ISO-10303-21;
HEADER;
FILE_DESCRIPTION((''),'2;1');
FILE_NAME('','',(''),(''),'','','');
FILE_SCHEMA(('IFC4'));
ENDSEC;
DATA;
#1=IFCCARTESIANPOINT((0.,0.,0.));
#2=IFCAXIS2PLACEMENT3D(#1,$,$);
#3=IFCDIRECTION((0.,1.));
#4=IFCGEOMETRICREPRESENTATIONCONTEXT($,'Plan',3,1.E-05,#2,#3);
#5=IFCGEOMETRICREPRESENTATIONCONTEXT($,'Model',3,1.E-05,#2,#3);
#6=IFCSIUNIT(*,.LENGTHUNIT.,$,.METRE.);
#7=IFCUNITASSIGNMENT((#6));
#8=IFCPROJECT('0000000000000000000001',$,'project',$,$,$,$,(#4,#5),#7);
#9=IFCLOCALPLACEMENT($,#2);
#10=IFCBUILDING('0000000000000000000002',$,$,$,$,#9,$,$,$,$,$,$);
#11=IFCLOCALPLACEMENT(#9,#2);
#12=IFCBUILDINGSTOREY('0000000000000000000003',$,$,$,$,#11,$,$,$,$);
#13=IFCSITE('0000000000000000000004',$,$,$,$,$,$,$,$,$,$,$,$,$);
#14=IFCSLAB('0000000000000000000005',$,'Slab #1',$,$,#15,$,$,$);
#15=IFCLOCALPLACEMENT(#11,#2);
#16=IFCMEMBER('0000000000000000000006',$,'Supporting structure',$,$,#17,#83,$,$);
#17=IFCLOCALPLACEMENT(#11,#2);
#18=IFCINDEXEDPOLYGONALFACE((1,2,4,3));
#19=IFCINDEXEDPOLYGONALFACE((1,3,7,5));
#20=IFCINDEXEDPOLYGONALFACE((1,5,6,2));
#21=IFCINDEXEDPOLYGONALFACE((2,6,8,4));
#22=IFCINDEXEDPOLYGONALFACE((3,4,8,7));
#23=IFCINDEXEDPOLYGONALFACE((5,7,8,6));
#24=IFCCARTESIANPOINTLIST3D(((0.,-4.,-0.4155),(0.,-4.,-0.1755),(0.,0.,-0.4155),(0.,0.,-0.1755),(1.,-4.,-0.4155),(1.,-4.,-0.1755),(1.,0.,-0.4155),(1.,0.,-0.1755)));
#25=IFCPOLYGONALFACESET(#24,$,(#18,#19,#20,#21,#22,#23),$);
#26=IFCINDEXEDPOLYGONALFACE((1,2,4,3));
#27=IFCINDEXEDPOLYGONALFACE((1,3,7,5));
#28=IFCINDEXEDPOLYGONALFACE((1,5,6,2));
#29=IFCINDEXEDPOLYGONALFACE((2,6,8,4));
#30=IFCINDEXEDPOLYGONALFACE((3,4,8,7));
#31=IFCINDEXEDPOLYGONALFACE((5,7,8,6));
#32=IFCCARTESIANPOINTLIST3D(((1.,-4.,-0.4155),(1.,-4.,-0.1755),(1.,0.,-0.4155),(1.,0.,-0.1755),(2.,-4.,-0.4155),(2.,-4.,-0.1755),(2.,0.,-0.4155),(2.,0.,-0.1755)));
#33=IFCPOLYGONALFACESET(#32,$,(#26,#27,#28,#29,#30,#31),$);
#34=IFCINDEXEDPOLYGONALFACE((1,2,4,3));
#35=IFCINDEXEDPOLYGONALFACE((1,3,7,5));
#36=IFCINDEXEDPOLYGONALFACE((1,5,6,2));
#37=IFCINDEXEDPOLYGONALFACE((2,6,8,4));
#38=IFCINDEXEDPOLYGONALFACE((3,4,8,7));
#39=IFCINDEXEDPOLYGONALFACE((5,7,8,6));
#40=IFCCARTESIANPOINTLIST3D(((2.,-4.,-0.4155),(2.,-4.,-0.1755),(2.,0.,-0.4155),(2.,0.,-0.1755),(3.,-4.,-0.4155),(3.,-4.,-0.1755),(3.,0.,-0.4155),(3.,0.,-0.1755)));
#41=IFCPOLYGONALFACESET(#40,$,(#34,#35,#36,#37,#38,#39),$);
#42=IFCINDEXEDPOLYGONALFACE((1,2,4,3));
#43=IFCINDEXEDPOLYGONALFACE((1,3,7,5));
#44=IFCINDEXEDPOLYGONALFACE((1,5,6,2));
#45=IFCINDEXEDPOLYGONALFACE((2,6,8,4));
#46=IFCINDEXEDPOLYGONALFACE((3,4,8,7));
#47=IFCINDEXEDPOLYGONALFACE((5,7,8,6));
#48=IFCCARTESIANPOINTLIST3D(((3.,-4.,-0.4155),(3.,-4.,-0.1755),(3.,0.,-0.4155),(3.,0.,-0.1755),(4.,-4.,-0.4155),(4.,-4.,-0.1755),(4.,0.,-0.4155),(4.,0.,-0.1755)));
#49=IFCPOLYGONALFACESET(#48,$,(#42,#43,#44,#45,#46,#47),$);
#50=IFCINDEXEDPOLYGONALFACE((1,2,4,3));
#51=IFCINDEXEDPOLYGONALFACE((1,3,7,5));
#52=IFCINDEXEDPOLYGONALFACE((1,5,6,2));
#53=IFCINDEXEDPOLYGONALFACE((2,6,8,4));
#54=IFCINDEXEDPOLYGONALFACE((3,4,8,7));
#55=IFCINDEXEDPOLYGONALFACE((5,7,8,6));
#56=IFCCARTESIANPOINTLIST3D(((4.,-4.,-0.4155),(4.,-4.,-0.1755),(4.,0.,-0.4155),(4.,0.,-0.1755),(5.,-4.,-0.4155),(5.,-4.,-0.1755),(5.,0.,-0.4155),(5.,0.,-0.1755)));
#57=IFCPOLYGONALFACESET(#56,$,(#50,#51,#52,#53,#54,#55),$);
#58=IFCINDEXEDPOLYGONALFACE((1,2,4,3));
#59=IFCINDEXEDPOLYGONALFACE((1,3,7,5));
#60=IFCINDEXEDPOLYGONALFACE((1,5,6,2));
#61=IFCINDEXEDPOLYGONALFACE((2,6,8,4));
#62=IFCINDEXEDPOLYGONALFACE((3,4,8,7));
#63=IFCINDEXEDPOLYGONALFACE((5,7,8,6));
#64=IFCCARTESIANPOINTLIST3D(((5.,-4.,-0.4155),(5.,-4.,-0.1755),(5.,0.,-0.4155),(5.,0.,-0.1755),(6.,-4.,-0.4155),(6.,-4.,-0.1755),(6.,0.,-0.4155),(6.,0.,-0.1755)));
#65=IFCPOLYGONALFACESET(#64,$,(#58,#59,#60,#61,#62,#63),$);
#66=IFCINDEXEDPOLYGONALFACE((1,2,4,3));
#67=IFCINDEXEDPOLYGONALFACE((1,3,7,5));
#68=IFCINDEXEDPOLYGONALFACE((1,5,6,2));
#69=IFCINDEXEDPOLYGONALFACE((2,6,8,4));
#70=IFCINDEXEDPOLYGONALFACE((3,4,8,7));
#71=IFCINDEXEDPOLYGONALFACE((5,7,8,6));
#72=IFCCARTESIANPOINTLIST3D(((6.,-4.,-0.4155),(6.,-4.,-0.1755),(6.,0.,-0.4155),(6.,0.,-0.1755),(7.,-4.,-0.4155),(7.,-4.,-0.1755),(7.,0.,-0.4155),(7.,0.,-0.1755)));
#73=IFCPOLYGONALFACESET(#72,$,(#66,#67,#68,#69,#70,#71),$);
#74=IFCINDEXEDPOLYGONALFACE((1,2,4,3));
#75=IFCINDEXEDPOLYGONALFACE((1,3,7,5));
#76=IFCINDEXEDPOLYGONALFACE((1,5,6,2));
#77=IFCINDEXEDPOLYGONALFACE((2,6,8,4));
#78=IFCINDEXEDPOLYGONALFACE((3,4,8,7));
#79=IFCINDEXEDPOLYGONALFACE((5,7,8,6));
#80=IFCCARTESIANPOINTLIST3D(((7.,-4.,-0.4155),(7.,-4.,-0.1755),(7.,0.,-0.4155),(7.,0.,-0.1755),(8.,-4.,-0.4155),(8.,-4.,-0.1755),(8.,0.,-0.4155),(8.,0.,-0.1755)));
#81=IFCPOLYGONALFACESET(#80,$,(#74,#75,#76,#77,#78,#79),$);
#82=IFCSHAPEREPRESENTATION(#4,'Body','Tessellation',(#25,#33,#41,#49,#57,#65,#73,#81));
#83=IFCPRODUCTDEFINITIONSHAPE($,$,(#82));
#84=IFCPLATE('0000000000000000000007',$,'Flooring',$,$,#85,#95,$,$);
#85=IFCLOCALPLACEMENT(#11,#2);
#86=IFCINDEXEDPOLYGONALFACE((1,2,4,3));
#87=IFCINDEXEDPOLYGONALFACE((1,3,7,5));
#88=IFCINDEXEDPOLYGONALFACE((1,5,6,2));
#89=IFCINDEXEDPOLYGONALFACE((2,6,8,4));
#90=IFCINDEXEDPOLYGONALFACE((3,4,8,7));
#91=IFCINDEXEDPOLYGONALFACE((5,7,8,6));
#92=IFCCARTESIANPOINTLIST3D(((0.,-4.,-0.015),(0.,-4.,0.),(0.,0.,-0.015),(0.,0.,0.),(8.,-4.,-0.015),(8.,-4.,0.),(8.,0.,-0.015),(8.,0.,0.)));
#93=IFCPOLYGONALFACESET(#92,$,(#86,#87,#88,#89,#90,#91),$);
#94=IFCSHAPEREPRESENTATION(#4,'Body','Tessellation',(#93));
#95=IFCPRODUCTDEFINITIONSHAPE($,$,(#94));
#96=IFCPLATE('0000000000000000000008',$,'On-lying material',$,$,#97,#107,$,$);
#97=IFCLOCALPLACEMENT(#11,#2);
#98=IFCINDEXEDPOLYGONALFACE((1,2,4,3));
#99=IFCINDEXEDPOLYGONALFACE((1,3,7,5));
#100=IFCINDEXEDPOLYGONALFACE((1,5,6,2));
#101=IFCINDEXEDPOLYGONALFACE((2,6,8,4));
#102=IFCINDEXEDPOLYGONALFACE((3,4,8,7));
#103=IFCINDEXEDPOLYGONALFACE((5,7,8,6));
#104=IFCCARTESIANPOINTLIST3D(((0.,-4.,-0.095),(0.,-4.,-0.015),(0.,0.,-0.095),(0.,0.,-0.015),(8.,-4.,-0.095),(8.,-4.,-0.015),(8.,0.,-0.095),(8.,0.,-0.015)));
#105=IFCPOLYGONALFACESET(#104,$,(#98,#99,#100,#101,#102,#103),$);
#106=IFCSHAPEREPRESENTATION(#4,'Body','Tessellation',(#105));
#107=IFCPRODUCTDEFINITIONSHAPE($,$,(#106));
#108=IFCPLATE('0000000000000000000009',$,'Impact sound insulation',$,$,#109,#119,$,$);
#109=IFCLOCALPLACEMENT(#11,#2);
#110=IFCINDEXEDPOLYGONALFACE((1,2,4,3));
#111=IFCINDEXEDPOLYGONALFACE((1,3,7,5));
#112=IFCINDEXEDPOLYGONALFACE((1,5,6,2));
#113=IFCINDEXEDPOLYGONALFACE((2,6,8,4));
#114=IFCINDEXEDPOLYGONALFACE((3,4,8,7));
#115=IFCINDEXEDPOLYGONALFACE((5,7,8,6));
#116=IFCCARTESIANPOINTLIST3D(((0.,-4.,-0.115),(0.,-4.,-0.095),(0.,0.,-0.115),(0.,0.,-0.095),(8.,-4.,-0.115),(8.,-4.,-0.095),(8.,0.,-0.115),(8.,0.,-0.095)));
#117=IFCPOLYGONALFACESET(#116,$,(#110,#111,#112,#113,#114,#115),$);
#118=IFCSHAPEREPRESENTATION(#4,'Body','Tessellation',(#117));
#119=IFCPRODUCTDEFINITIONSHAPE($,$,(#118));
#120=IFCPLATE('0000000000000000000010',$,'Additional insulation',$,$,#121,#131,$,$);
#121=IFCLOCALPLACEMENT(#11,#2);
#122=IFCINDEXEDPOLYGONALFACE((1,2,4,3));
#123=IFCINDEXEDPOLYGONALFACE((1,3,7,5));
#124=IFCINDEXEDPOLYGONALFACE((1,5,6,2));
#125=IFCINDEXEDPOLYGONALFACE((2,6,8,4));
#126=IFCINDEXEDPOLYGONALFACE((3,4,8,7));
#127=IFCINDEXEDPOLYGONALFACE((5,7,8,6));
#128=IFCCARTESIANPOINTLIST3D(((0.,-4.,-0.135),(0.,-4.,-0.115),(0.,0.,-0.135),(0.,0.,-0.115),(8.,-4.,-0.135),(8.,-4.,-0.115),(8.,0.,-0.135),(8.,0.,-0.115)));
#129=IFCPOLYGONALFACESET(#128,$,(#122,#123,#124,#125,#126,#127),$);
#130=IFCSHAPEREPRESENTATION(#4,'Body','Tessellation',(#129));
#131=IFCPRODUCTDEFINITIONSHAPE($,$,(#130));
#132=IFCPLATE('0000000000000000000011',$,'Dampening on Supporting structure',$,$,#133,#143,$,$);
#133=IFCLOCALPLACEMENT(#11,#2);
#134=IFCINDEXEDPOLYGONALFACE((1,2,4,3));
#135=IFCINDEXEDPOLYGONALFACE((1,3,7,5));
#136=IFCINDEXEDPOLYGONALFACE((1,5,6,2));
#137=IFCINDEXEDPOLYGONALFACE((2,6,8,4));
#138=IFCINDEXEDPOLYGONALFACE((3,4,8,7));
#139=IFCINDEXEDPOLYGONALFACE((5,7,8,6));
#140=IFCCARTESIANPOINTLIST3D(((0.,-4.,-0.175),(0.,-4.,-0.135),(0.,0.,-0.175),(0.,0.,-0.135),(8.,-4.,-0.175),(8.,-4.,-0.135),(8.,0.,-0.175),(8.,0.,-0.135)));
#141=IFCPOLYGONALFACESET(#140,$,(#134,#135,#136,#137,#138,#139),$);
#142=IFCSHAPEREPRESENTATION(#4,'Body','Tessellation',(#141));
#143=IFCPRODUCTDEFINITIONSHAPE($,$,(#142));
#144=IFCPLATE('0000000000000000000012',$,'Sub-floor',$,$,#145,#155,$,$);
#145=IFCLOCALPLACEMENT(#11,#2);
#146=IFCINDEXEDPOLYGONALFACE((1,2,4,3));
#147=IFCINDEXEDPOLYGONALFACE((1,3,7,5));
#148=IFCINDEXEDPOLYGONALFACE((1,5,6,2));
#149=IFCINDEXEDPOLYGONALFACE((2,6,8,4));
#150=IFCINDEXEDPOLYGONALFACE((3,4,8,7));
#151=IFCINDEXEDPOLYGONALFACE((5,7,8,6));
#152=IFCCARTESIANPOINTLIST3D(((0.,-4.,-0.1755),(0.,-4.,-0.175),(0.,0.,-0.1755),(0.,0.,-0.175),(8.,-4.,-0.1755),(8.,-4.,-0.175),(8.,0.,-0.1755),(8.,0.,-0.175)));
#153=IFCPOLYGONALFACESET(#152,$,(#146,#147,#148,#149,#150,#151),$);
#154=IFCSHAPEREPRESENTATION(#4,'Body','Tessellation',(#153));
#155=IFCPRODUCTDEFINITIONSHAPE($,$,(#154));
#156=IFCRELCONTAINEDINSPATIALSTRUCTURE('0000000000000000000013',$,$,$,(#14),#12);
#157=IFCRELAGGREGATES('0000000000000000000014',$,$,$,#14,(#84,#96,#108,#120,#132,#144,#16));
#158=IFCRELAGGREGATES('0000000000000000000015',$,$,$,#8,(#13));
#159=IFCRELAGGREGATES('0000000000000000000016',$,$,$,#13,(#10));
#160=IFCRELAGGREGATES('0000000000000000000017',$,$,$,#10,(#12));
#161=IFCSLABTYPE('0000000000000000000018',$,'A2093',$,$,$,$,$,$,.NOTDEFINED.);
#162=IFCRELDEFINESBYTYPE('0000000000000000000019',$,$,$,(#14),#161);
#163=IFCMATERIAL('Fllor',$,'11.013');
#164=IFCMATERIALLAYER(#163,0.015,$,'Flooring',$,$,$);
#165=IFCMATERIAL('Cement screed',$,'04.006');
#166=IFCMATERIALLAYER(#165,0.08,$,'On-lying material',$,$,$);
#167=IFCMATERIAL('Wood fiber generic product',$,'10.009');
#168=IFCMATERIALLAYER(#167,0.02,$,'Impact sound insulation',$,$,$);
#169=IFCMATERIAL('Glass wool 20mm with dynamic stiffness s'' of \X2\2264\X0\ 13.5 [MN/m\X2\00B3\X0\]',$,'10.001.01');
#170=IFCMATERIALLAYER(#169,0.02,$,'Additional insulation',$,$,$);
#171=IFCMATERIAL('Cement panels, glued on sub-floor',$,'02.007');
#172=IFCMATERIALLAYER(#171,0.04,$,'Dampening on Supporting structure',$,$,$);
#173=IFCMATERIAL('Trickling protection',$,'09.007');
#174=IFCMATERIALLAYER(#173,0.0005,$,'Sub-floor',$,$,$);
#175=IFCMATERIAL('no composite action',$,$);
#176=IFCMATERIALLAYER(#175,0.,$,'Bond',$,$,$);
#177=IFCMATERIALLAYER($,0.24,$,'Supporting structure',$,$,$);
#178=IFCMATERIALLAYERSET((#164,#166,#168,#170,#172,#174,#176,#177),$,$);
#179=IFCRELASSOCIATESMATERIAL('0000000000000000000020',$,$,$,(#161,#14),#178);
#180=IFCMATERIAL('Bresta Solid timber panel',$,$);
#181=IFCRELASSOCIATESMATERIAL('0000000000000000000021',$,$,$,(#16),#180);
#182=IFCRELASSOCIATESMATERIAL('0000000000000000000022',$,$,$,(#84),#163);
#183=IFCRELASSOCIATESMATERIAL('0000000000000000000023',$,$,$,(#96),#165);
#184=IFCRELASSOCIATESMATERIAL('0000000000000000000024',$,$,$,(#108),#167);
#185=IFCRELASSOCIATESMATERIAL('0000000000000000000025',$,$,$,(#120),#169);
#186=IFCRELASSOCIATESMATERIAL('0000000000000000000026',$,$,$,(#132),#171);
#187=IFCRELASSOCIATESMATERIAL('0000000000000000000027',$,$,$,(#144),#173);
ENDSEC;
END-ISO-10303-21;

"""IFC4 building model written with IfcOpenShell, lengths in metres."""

from ifc_helpers import new_model, si_unit, direction, frame, frame_2d, origin, origin_with_axes, place, context, project, spatial, rectangle, extrude, material, layer, layer_set, type_object, element, aggregate, save


model = new_model("IFC4")

# Units and contexts
plan_context = context("Plan", 3, precision=1e-05, world=origin(), true_north=direction((0.0, 1.0)))
model_context = context("Model", 3, precision=1e-05, world=origin(), true_north=direction((0.0, 1.0)))
ifc_project = project(units=[si_unit("LENGTHUNIT", "METRE")], contexts=[plan_context, model_context])

# Site, building, storey
site = spatial("IfcSite", under=ifc_project)
building_placement = place(None, origin())
building = spatial("IfcBuilding", under=site, at=building_placement)
storey_placement = place(building_placement, origin())
storey = spatial("IfcBuildingStorey", under=building, at=storey_placement)

# Slab, member, plates
ifc_material_1 = material(Name="Fllor", Category="11.013")
ifc_layer_1 = layer(ifc_material_1, 0.015, Name="Flooring")
ifc_material_2 = material(Name="Cement screed", Category="04.006")
ifc_layer_2 = layer(ifc_material_2, 0.08, Name="On-lying material")
ifc_material_3 = material(Name="Wood fiber generic product", Category="10.009")
ifc_layer_3 = layer(ifc_material_3, 0.02, Name="Impact sound insulation")
ifc_material_4 = material(Name="Glass wool 20mm with dynamic stiffness s' of ≤ 13.5 [MN/m³]", Category="10.001.01")
ifc_layer_4 = layer(ifc_material_4, 0.02, Name="Additional insulation")
ifc_material_5 = material(Name="Cement panels, glued on sub-floor", Category="02.007")
ifc_layer_5 = layer(ifc_material_5, 0.04, Name="Dampening on Supporting structure")
ifc_material_6 = material(Name="Trickling protection", Category="09.007")
ifc_layer_6 = layer(ifc_material_6, 0.0005, Name="Sub-floor")
ifc_material_7 = material(Name="no composite action")
ifc_layer_7 = layer(ifc_material_7, 0.0, Name="Bond")
ifc_layer_8 = layer(None, 0.24, Name="Supporting structure")
ifc_layer_set = layer_set([ifc_layer_1, ifc_layer_2, ifc_layer_3, ifc_layer_4, ifc_layer_5, ifc_layer_6, ifc_layer_7, ifc_layer_8])
slab_type = type_object("IfcSlabType", Name="A2093", PredefinedType="NOTDEFINED", material=ifc_layer_set)
slab_placement = place(None, frame((0.0, 0.0, 0.0), z_axis=(0.0, 0.0, -1.0), x_axis=(1.0, 0.0, 0.0)))
slab = element("IfcSlab", 1, at=slab_placement, inside=storey, type_object=slab_type, material=ifc_layer_set, Name="Slab #1")
ifc_material_8 = material(Name="Bresta Solid timber panel")
member_placement = place(slab_placement, origin())
member = element("IfcMember", 2, at=member_placement, material=ifc_material_8, Name="Supporting structure", context=plan_context, shape_type="SweptSolid", body=[
    extrude(rectangle(XDim=1.0, YDim=0.24, at=frame_2d((0.5, 0.12), x_axis=(1.0, 0.0))), frame((0.0, 4.0, 0.1755), z_axis=(0.0, -1.0, 0.0), x_axis=(1.0, 0.0, 0.0)), (0.0, 0.0, 1.0), 4.0),
    extrude(rectangle(XDim=1.0, YDim=0.24, at=frame_2d((0.5, 0.12), x_axis=(1.0, 0.0))), frame((1.0, 4.0, 0.1755), z_axis=(0.0, -1.0, 0.0), x_axis=(1.0, 0.0, 0.0)), (0.0, 0.0, 1.0), 4.0),
    extrude(rectangle(XDim=1.0, YDim=0.24, at=frame_2d((0.5, 0.12), x_axis=(1.0, 0.0))), frame((2.0, 4.0, 0.1755), z_axis=(0.0, -1.0, 0.0), x_axis=(1.0, 0.0, 0.0)), (0.0, 0.0, 1.0), 4.0),
    extrude(rectangle(XDim=1.0, YDim=0.24, at=frame_2d((0.5, 0.12), x_axis=(1.0, 0.0))), frame((3.0, 4.0, 0.1755), z_axis=(0.0, -1.0, 0.0), x_axis=(1.0, 0.0, 0.0)), (0.0, 0.0, 1.0), 4.0),
    extrude(rectangle(XDim=1.0, YDim=0.24, at=frame_2d((0.5, 0.12), x_axis=(1.0, 0.0))), frame((4.0, 4.0, 0.1755), z_axis=(0.0, -1.0, 0.0), x_axis=(1.0, 0.0, 0.0)), (0.0, 0.0, 1.0), 4.0),
    extrude(rectangle(XDim=1.0, YDim=0.24, at=frame_2d((0.5, 0.12), x_axis=(1.0, 0.0))), frame((5.0, 4.0, 0.1755), z_axis=(0.0, -1.0, 0.0), x_axis=(1.0, 0.0, 0.0)), (0.0, 0.0, 1.0), 4.0),
    extrude(rectangle(XDim=1.0, YDim=0.24, at=frame_2d((0.5, 0.12), x_axis=(1.0, 0.0))), frame((6.0, 4.0, 0.1755), z_axis=(0.0, -1.0, 0.0), x_axis=(1.0, 0.0, 0.0)), (0.0, 0.0, 1.0), 4.0),
    extrude(rectangle(XDim=1.0, YDim=0.24, at=frame_2d((0.5, 0.12), x_axis=(1.0, 0.0))), frame((7.0, 4.0, 0.1755), z_axis=(0.0, -1.0, 0.0), x_axis=(1.0, 0.0, 0.0)), (0.0, 0.0, 1.0), 4.0),
])
plate_1_placement = place(slab_placement, origin())
plate_1 = element("IfcPlate", 3, at=plate_1_placement, material=ifc_material_1, Name="Flooring", context=plan_context, shape_type="SweptSolid", body=[
    extrude(rectangle(XDim=8.0, YDim=4.0, at=frame_2d((4.0, 2.0), x_axis=(1.0, 0.0))), origin_with_axes(), (0.0, 0.0, 1.0), 0.015),
])
plate_2_placement = place(slab_placement, origin())
plate_2 = element("IfcPlate", 4, at=plate_2_placement, material=ifc_material_2, Name="On-lying material", context=plan_context, shape_type="SweptSolid", body=[
    extrude(rectangle(XDim=8.0, YDim=4.0, at=frame_2d((4.0, 2.0), x_axis=(1.0, 0.0))), frame((0.0, 0.0, 0.015), z_axis=(0.0, 0.0, 1.0), x_axis=(1.0, 0.0, 0.0)), (0.0, 0.0, 1.0), 0.08),
])
plate_3_placement = place(slab_placement, origin())
plate_3 = element("IfcPlate", 5, at=plate_3_placement, material=ifc_material_3, Name="Impact sound insulation", context=plan_context, shape_type="SweptSolid", body=[
    extrude(rectangle(XDim=8.0, YDim=4.0, at=frame_2d((4.0, 2.0), x_axis=(1.0, 0.0))), frame((0.0, 0.0, 0.095), z_axis=(0.0, 0.0, 1.0), x_axis=(1.0, 0.0, 0.0)), (0.0, 0.0, 1.0), 0.02),
])
plate_4_placement = place(slab_placement, origin())
plate_4 = element("IfcPlate", 6, at=plate_4_placement, material=ifc_material_4, Name="Additional insulation", context=plan_context, shape_type="SweptSolid", body=[
    extrude(rectangle(XDim=8.0, YDim=4.0, at=frame_2d((4.0, 2.0), x_axis=(1.0, 0.0))), frame((0.0, 0.0, 0.115), z_axis=(0.0, 0.0, 1.0), x_axis=(1.0, 0.0, 0.0)), (0.0, 0.0, 1.0), 0.02),
])
plate_5_placement = place(slab_placement, origin())
plate_5 = element("IfcPlate", 7, at=plate_5_placement, material=ifc_material_5, Name="Dampening on Supporting structure", context=plan_context, shape_type="SweptSolid", body=[
    extrude(rectangle(XDim=8.0, YDim=4.0, at=frame_2d((4.0, 2.0), x_axis=(1.0, 0.0))), frame((0.0, 0.0, 0.135), z_axis=(0.0, 0.0, 1.0), x_axis=(1.0, 0.0, 0.0)), (0.0, 0.0, 1.0), 0.04),
])
plate_6_placement = place(slab_placement, origin())
plate_6 = element("IfcPlate", 8, at=plate_6_placement, material=ifc_material_6, Name="Sub-floor", context=plan_context, shape_type="SweptSolid", body=[
    extrude(rectangle(XDim=8.0, YDim=4.0, at=frame_2d((4.0, 2.0), x_axis=(1.0, 0.0))), frame((0.0, 0.0, 0.175), z_axis=(0.0, 0.0, 1.0), x_axis=(1.0, 0.0, 0.0)), (0.0, 0.0, 1.0), 0.0005),
])
aggregate(slab, [plate_1, plate_2, plate_3, plate_4, plate_5, plate_6, member])

save(model, "model.ifc")
